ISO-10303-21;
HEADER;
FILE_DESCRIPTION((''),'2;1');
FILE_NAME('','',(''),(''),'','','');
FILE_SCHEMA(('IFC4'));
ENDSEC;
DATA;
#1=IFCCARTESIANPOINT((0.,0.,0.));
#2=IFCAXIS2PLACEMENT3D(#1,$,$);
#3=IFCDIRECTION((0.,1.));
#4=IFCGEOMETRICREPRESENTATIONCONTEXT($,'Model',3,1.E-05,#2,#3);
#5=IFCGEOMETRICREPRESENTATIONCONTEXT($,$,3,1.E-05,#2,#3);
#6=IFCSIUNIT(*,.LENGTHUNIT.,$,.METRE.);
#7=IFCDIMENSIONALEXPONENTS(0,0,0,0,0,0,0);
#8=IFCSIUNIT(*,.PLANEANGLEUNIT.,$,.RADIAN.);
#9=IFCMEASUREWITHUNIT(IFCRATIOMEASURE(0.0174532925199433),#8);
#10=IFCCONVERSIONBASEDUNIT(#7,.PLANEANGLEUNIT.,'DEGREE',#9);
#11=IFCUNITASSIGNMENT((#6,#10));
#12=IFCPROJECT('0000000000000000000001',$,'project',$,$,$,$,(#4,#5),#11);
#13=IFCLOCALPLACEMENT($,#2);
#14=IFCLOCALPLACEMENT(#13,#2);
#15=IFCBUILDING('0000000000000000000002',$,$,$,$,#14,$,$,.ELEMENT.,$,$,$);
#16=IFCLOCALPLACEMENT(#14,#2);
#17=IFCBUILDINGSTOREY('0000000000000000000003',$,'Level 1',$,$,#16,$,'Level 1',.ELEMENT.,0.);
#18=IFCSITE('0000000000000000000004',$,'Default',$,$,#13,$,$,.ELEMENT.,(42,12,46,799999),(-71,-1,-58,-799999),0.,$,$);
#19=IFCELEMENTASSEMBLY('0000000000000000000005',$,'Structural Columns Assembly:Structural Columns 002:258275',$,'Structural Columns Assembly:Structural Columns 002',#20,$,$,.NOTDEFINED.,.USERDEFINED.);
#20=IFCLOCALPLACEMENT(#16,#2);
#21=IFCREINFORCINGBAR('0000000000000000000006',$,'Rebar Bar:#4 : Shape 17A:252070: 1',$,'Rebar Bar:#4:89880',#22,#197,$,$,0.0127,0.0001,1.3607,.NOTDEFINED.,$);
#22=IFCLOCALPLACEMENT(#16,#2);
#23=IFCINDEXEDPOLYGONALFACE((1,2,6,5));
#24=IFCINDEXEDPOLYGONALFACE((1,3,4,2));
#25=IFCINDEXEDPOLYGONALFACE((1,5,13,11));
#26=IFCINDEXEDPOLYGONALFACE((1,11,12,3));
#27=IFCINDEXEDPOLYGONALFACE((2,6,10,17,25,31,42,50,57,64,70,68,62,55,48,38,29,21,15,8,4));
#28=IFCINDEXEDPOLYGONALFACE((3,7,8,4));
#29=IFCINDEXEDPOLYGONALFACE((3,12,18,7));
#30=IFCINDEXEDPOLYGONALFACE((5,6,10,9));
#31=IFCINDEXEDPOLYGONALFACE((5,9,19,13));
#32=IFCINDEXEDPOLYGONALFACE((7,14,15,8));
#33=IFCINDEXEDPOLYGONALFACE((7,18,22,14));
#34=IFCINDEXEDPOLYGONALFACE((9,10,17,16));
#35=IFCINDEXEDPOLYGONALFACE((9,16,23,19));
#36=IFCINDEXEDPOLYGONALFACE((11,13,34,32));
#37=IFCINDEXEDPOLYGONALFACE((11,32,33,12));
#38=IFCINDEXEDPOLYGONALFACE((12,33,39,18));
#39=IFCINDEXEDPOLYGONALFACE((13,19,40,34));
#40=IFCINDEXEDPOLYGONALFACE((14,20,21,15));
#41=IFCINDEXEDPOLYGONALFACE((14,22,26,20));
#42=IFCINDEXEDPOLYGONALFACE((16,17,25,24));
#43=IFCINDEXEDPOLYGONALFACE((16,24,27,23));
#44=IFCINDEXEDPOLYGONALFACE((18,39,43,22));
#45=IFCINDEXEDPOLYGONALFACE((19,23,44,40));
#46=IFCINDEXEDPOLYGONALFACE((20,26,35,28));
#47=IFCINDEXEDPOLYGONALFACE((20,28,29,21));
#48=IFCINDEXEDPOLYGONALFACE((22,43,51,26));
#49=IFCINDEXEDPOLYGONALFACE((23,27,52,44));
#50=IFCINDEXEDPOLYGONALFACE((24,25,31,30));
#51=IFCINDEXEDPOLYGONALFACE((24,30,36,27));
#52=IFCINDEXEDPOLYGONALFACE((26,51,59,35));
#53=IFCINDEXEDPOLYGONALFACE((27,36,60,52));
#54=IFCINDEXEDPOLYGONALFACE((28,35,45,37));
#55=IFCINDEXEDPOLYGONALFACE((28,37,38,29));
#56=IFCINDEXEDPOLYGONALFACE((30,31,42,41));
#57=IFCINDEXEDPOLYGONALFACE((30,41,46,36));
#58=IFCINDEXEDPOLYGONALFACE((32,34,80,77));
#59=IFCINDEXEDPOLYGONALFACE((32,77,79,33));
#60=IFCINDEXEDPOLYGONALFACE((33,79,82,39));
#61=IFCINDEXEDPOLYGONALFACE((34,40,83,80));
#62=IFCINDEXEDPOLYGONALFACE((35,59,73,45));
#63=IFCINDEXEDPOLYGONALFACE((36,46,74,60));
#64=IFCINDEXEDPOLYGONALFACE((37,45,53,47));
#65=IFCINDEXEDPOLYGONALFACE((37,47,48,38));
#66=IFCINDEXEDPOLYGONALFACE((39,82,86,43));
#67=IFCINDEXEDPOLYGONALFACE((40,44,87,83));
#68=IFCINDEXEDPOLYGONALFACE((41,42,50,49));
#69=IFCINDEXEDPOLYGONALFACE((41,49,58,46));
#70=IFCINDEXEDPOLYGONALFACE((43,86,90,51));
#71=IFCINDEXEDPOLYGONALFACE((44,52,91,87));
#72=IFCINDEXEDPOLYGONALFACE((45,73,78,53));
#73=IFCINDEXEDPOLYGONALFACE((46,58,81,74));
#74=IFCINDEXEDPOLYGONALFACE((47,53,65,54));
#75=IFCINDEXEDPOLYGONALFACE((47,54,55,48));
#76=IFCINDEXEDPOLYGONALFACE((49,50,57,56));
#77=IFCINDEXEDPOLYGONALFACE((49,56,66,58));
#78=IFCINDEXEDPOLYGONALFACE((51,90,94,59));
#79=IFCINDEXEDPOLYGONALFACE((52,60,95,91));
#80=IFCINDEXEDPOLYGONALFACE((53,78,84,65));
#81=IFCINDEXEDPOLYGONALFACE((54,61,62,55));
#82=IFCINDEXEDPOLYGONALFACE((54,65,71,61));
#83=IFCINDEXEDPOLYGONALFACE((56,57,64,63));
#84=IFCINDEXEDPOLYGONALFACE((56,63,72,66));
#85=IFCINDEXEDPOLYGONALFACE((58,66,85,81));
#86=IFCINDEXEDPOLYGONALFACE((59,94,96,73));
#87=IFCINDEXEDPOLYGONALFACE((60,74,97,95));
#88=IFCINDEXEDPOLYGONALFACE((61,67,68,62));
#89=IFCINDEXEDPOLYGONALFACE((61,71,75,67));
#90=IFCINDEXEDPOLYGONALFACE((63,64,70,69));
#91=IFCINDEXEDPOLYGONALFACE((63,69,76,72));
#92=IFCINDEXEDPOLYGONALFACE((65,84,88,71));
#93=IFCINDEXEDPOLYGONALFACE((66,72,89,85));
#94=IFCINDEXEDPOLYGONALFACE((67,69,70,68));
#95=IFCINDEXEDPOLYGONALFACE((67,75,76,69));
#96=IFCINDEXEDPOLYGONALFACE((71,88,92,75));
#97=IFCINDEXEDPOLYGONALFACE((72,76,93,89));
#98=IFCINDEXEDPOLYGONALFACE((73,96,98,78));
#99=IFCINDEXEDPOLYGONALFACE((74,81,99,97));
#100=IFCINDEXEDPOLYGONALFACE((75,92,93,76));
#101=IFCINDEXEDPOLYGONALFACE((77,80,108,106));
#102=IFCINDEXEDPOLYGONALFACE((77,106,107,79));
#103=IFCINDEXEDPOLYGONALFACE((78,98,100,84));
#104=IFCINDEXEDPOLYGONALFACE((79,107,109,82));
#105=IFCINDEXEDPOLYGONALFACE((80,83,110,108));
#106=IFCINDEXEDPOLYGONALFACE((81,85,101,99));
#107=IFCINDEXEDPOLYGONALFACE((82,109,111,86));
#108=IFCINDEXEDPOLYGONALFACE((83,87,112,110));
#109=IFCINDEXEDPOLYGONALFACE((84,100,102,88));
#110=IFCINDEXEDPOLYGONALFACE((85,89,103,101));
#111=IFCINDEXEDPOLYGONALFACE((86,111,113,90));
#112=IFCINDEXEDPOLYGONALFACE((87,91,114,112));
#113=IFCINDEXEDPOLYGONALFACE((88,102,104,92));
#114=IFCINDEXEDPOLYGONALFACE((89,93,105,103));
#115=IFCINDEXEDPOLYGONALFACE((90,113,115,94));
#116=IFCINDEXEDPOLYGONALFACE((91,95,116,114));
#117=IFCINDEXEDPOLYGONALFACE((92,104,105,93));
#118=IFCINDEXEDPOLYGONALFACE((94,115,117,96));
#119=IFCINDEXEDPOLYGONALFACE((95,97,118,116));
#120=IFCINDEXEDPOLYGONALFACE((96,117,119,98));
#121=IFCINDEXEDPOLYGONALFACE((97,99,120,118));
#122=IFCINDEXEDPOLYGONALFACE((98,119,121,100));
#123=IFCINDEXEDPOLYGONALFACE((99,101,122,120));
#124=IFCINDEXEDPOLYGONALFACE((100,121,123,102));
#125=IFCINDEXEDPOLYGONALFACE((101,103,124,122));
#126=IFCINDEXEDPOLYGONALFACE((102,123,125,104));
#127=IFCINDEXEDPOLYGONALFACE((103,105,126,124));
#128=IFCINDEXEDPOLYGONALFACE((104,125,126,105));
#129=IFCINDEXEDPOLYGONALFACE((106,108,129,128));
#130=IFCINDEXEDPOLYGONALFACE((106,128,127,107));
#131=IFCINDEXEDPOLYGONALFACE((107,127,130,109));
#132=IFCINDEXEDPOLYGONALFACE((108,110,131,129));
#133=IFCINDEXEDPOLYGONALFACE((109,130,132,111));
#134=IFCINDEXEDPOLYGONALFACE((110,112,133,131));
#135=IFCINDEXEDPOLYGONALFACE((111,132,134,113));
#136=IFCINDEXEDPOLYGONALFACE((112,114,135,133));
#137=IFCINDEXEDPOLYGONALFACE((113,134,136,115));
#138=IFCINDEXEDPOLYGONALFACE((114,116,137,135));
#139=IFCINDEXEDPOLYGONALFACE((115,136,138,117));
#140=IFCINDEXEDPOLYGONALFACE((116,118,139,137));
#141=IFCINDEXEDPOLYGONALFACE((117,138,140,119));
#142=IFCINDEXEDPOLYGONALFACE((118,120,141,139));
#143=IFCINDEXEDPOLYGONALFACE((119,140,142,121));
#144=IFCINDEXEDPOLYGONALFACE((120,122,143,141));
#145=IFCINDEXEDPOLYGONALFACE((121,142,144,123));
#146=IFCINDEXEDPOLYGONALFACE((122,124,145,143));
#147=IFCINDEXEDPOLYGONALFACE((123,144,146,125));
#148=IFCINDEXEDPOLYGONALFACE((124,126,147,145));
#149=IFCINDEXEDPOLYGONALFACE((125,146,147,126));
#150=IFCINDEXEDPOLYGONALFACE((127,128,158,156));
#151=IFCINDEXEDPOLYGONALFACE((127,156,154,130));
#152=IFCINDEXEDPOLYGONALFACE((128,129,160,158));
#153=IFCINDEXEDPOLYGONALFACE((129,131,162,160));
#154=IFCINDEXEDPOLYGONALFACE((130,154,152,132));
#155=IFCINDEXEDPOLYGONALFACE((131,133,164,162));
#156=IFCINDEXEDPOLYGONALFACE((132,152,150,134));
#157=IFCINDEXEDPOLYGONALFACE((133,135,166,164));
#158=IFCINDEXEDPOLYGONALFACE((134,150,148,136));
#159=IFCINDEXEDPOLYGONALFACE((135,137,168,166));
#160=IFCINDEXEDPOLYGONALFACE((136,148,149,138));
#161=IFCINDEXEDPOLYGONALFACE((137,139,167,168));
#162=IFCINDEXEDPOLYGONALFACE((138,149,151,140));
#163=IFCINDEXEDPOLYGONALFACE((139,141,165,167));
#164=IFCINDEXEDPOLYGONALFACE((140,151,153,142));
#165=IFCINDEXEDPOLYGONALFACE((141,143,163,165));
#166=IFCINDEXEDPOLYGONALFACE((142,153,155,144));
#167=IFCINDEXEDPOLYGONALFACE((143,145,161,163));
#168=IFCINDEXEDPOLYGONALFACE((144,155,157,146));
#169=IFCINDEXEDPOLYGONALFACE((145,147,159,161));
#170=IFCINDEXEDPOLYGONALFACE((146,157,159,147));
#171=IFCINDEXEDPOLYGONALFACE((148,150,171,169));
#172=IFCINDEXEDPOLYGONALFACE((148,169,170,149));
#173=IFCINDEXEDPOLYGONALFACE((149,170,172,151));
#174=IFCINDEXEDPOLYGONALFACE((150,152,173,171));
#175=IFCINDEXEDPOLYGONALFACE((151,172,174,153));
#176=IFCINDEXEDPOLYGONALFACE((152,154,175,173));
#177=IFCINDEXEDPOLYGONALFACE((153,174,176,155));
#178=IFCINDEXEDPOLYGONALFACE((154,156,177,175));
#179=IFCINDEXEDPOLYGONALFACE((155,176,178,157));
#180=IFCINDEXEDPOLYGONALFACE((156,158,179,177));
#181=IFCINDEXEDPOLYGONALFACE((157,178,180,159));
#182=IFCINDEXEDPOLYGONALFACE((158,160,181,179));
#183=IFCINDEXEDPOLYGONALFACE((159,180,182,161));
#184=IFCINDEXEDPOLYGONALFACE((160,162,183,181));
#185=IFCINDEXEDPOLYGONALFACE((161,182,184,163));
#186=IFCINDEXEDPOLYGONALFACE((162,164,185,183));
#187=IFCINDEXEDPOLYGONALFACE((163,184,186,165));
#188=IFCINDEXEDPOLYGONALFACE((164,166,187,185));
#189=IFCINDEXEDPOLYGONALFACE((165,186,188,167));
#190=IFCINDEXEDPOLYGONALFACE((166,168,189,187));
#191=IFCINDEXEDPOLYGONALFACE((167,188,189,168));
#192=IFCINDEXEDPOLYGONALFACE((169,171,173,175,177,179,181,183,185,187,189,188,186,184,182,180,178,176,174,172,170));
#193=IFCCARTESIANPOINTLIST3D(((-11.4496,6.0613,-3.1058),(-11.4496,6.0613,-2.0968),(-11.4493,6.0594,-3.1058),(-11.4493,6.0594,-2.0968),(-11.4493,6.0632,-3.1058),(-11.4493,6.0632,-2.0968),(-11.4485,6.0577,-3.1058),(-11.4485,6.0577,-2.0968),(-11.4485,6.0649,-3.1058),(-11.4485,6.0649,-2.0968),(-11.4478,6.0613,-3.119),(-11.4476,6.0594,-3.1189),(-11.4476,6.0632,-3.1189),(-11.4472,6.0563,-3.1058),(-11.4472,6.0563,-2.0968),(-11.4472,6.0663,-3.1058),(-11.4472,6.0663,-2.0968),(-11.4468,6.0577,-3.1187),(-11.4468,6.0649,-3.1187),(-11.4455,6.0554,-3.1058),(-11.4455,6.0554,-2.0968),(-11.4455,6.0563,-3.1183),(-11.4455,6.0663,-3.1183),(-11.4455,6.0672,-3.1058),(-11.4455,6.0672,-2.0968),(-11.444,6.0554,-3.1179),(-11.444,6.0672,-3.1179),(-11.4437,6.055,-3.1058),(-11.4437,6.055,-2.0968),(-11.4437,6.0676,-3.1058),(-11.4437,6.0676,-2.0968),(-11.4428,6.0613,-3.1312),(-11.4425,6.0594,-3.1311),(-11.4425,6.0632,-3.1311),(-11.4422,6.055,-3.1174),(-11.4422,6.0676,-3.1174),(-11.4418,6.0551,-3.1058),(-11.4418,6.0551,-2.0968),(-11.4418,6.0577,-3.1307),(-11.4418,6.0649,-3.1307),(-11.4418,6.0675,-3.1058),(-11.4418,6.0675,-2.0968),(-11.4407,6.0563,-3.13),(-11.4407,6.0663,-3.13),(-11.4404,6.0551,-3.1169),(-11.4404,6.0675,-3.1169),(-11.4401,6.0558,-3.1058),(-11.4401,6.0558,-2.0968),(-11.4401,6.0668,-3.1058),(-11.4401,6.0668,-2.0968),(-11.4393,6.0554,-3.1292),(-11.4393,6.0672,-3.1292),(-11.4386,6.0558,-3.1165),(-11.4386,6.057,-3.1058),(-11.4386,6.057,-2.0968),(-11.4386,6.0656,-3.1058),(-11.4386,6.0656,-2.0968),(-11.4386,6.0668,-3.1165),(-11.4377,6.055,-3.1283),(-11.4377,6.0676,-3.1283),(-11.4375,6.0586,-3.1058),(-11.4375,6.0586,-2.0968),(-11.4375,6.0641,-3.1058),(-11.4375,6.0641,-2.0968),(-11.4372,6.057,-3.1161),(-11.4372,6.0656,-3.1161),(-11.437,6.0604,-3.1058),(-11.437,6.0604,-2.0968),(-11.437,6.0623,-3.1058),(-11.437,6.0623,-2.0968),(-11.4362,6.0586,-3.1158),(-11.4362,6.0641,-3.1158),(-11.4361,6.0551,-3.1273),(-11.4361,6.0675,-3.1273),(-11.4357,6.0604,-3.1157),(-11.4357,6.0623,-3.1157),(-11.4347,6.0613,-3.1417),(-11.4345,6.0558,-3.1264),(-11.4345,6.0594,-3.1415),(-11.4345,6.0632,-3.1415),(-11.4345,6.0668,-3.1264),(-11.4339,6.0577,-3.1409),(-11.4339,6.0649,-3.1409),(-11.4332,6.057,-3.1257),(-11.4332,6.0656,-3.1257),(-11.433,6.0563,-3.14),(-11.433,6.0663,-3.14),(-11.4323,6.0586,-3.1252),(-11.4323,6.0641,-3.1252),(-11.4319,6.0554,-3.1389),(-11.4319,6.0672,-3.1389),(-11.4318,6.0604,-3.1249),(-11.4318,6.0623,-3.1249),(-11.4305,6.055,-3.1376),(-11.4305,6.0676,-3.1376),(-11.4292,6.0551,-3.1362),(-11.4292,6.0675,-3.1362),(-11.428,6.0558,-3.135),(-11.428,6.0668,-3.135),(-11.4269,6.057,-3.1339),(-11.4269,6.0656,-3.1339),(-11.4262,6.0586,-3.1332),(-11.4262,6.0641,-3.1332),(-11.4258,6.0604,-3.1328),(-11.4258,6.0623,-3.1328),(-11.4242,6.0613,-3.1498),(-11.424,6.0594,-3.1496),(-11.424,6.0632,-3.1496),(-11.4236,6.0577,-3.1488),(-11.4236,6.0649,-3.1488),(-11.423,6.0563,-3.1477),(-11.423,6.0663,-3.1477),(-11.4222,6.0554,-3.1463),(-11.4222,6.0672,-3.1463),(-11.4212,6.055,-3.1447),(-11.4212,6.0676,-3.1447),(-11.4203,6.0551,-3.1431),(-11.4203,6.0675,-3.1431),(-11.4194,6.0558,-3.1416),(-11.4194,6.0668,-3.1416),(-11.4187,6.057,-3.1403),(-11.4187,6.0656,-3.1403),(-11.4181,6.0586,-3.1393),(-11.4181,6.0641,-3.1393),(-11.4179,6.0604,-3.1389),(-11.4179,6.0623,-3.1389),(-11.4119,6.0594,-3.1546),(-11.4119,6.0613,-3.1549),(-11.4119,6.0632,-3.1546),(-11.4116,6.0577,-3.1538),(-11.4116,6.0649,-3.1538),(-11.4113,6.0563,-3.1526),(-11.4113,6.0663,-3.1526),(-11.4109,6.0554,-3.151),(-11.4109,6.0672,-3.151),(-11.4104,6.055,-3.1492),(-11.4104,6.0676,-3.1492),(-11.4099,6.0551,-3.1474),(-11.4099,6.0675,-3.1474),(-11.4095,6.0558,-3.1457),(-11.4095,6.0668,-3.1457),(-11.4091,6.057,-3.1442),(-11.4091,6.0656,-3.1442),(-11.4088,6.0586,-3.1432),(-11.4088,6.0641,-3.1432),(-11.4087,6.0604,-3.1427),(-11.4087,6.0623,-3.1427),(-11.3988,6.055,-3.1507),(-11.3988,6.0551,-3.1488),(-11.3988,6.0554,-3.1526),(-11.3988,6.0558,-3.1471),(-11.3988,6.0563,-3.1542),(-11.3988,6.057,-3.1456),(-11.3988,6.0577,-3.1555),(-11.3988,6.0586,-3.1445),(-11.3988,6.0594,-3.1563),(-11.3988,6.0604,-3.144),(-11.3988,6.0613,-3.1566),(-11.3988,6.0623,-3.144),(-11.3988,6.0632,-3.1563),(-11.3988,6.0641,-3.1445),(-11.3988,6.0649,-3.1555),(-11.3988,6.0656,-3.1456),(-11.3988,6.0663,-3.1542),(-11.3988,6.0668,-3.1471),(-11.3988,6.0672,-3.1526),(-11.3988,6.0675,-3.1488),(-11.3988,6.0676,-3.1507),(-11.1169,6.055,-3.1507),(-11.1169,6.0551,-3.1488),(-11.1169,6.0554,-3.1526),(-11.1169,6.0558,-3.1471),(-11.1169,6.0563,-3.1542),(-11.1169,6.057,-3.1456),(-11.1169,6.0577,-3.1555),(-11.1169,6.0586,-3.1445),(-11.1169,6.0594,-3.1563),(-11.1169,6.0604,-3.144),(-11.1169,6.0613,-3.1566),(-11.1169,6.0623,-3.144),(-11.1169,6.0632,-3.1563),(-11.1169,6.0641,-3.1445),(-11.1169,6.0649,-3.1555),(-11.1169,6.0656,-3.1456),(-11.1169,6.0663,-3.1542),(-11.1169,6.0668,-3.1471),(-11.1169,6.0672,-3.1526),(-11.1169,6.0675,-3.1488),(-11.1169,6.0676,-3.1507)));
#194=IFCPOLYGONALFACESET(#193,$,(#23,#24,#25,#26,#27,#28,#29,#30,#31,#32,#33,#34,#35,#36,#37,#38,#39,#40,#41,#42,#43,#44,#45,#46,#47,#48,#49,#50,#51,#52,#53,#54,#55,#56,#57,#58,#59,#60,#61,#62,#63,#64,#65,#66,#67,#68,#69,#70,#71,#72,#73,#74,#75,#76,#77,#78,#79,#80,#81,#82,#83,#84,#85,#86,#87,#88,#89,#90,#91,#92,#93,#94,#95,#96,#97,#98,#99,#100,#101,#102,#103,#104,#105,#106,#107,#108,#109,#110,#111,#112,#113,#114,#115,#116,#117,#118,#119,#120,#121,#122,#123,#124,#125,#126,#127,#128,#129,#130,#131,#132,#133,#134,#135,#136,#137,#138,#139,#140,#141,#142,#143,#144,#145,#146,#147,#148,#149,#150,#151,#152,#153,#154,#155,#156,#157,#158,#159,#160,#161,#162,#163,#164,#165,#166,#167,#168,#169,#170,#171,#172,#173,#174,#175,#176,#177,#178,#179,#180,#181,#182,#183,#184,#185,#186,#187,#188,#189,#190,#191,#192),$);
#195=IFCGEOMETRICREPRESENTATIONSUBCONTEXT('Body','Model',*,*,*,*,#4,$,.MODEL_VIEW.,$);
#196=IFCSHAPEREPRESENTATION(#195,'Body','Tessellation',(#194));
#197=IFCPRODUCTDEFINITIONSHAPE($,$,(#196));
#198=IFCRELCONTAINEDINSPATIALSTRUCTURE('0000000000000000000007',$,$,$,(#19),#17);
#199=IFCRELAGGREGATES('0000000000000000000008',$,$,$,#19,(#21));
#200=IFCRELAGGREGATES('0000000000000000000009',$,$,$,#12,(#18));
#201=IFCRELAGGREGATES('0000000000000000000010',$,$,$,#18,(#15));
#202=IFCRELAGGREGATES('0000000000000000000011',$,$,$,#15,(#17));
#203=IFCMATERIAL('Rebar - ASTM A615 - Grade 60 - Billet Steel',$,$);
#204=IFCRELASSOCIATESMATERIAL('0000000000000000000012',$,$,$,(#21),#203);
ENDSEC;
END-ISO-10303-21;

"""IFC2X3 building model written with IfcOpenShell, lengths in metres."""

from ifc_helpers import new_model, entity, si_unit, converted_unit, direction, origin, place, context, subcontext, project, spatial, material, element, aggregate, save


model = new_model("IFC2X3")

# Units and contexts
model_context = context("Model", 3, precision=1e-05, world=origin(), true_north=direction((0.0, 1.0)))
context_of_model = context(None, 3, precision=1e-05, world=origin(), true_north=direction((0.0, 1.0)))
body_context = subcontext(model_context, "Body", "Model", "MODEL_VIEW")
ifc_project = project(units=[si_unit("LENGTHUNIT", "METRE"), converted_unit("PLANEANGLEUNIT", "DEGREE", entity("IfcRatioMeasure", 0.0174532925199433), si_unit("PLANEANGLEUNIT", "RADIAN"), dimensions=[0, 0, 0, 0, 0, 0, 0])], contexts=[model_context, context_of_model])

# Site, building, storey
site_placement = place(None, origin())
site = spatial("IfcSite", under=ifc_project, at=site_placement, Name="Default", CompositionType="ELEMENT", RefLatitude=(42, 12, 46, 799999), RefLongitude=(-71, -1, -58, -799999), RefElevation=0.0)
building_placement = place(site_placement, origin())
building = spatial("IfcBuilding", under=site, at=building_placement, CompositionType="ELEMENT")
storey_placement = place(building_placement, origin())
storey = spatial("IfcBuildingStorey", under=building, at=storey_placement, Name="Level 1", LongName="Level 1", CompositionType="ELEMENT", Elevation=0.0)

# Element assembly, reinforcing bar
assembly_1_placement = place(storey_placement, origin())
assembly_1 = element("IfcElementAssembly", 1, at=assembly_1_placement, inside=storey, Name="Structural Columns Assembly:Structural Columns 002:258275", ObjectType="Structural Columns Assembly:Structural Columns 002", AssemblyPlace="NOTDEFINED", PredefinedType="USERDEFINED")
ifc_material_1 = material(Name="Rebar - ASTM A615 - Grade 60 - Billet Steel")
reinforcing_bar_1_placement = place(assembly_1_placement, origin())
reinforcing_bar_1 = element("IfcReinforcingBar", 2, at=reinforcing_bar_1_placement, material=ifc_material_1, Name="Rebar Bar:#4 : Shape 17A:252070: 1", ObjectType="Rebar Bar:#4:89880", BarLength=1.3607, BarRole="NOTDEFINED", CrossSectionArea=0.0001, NominalDiameter=0.0127, context=body_context, shape_type="AdvancedSweptSolid", body=[
    entity("IfcSweptDiskSolid", entity("IfcCompositeCurve", [entity("IfcCompositeCurveSegment", "CONTINUOUS", True, entity("IfcPolyline", [entity("IfcCartesianPoint", [-11.4432, 6.0613, -2.0968]), entity("IfcCartesianPoint", [-11.4432, 6.0613, -3.1058])])), entity("IfcCompositeCurveSegment", "CONTINUOUS", True, entity("IfcTrimmedCurve", entity("IfcCircle", entity("IfcAxis2Placement3D", entity("IfcCartesianPoint", [-11.3988, 6.0613, -3.1058]), entity("IfcDirection", [0.0, -1.0, 0.0]), entity("IfcDirection", [0.0, 0.0, -1.0])), 0.0445), [entity("IfcParameterValue", 270.0)], [entity("IfcParameterValue", 360.0)], True, "PARAMETER")), entity("IfcCompositeCurveSegment", "CONTINUOUS", True, entity("IfcPolyline", [entity("IfcCartesianPoint", [-11.3988, 6.0613, -3.1503]), entity("IfcCartesianPoint", [-11.1169, 6.0613, -3.1503])]))], False), 0.0063, None, 0.0, 92.0),
])
aggregate(assembly_1, [reinforcing_bar_1])

save(model, "model.ifc")
